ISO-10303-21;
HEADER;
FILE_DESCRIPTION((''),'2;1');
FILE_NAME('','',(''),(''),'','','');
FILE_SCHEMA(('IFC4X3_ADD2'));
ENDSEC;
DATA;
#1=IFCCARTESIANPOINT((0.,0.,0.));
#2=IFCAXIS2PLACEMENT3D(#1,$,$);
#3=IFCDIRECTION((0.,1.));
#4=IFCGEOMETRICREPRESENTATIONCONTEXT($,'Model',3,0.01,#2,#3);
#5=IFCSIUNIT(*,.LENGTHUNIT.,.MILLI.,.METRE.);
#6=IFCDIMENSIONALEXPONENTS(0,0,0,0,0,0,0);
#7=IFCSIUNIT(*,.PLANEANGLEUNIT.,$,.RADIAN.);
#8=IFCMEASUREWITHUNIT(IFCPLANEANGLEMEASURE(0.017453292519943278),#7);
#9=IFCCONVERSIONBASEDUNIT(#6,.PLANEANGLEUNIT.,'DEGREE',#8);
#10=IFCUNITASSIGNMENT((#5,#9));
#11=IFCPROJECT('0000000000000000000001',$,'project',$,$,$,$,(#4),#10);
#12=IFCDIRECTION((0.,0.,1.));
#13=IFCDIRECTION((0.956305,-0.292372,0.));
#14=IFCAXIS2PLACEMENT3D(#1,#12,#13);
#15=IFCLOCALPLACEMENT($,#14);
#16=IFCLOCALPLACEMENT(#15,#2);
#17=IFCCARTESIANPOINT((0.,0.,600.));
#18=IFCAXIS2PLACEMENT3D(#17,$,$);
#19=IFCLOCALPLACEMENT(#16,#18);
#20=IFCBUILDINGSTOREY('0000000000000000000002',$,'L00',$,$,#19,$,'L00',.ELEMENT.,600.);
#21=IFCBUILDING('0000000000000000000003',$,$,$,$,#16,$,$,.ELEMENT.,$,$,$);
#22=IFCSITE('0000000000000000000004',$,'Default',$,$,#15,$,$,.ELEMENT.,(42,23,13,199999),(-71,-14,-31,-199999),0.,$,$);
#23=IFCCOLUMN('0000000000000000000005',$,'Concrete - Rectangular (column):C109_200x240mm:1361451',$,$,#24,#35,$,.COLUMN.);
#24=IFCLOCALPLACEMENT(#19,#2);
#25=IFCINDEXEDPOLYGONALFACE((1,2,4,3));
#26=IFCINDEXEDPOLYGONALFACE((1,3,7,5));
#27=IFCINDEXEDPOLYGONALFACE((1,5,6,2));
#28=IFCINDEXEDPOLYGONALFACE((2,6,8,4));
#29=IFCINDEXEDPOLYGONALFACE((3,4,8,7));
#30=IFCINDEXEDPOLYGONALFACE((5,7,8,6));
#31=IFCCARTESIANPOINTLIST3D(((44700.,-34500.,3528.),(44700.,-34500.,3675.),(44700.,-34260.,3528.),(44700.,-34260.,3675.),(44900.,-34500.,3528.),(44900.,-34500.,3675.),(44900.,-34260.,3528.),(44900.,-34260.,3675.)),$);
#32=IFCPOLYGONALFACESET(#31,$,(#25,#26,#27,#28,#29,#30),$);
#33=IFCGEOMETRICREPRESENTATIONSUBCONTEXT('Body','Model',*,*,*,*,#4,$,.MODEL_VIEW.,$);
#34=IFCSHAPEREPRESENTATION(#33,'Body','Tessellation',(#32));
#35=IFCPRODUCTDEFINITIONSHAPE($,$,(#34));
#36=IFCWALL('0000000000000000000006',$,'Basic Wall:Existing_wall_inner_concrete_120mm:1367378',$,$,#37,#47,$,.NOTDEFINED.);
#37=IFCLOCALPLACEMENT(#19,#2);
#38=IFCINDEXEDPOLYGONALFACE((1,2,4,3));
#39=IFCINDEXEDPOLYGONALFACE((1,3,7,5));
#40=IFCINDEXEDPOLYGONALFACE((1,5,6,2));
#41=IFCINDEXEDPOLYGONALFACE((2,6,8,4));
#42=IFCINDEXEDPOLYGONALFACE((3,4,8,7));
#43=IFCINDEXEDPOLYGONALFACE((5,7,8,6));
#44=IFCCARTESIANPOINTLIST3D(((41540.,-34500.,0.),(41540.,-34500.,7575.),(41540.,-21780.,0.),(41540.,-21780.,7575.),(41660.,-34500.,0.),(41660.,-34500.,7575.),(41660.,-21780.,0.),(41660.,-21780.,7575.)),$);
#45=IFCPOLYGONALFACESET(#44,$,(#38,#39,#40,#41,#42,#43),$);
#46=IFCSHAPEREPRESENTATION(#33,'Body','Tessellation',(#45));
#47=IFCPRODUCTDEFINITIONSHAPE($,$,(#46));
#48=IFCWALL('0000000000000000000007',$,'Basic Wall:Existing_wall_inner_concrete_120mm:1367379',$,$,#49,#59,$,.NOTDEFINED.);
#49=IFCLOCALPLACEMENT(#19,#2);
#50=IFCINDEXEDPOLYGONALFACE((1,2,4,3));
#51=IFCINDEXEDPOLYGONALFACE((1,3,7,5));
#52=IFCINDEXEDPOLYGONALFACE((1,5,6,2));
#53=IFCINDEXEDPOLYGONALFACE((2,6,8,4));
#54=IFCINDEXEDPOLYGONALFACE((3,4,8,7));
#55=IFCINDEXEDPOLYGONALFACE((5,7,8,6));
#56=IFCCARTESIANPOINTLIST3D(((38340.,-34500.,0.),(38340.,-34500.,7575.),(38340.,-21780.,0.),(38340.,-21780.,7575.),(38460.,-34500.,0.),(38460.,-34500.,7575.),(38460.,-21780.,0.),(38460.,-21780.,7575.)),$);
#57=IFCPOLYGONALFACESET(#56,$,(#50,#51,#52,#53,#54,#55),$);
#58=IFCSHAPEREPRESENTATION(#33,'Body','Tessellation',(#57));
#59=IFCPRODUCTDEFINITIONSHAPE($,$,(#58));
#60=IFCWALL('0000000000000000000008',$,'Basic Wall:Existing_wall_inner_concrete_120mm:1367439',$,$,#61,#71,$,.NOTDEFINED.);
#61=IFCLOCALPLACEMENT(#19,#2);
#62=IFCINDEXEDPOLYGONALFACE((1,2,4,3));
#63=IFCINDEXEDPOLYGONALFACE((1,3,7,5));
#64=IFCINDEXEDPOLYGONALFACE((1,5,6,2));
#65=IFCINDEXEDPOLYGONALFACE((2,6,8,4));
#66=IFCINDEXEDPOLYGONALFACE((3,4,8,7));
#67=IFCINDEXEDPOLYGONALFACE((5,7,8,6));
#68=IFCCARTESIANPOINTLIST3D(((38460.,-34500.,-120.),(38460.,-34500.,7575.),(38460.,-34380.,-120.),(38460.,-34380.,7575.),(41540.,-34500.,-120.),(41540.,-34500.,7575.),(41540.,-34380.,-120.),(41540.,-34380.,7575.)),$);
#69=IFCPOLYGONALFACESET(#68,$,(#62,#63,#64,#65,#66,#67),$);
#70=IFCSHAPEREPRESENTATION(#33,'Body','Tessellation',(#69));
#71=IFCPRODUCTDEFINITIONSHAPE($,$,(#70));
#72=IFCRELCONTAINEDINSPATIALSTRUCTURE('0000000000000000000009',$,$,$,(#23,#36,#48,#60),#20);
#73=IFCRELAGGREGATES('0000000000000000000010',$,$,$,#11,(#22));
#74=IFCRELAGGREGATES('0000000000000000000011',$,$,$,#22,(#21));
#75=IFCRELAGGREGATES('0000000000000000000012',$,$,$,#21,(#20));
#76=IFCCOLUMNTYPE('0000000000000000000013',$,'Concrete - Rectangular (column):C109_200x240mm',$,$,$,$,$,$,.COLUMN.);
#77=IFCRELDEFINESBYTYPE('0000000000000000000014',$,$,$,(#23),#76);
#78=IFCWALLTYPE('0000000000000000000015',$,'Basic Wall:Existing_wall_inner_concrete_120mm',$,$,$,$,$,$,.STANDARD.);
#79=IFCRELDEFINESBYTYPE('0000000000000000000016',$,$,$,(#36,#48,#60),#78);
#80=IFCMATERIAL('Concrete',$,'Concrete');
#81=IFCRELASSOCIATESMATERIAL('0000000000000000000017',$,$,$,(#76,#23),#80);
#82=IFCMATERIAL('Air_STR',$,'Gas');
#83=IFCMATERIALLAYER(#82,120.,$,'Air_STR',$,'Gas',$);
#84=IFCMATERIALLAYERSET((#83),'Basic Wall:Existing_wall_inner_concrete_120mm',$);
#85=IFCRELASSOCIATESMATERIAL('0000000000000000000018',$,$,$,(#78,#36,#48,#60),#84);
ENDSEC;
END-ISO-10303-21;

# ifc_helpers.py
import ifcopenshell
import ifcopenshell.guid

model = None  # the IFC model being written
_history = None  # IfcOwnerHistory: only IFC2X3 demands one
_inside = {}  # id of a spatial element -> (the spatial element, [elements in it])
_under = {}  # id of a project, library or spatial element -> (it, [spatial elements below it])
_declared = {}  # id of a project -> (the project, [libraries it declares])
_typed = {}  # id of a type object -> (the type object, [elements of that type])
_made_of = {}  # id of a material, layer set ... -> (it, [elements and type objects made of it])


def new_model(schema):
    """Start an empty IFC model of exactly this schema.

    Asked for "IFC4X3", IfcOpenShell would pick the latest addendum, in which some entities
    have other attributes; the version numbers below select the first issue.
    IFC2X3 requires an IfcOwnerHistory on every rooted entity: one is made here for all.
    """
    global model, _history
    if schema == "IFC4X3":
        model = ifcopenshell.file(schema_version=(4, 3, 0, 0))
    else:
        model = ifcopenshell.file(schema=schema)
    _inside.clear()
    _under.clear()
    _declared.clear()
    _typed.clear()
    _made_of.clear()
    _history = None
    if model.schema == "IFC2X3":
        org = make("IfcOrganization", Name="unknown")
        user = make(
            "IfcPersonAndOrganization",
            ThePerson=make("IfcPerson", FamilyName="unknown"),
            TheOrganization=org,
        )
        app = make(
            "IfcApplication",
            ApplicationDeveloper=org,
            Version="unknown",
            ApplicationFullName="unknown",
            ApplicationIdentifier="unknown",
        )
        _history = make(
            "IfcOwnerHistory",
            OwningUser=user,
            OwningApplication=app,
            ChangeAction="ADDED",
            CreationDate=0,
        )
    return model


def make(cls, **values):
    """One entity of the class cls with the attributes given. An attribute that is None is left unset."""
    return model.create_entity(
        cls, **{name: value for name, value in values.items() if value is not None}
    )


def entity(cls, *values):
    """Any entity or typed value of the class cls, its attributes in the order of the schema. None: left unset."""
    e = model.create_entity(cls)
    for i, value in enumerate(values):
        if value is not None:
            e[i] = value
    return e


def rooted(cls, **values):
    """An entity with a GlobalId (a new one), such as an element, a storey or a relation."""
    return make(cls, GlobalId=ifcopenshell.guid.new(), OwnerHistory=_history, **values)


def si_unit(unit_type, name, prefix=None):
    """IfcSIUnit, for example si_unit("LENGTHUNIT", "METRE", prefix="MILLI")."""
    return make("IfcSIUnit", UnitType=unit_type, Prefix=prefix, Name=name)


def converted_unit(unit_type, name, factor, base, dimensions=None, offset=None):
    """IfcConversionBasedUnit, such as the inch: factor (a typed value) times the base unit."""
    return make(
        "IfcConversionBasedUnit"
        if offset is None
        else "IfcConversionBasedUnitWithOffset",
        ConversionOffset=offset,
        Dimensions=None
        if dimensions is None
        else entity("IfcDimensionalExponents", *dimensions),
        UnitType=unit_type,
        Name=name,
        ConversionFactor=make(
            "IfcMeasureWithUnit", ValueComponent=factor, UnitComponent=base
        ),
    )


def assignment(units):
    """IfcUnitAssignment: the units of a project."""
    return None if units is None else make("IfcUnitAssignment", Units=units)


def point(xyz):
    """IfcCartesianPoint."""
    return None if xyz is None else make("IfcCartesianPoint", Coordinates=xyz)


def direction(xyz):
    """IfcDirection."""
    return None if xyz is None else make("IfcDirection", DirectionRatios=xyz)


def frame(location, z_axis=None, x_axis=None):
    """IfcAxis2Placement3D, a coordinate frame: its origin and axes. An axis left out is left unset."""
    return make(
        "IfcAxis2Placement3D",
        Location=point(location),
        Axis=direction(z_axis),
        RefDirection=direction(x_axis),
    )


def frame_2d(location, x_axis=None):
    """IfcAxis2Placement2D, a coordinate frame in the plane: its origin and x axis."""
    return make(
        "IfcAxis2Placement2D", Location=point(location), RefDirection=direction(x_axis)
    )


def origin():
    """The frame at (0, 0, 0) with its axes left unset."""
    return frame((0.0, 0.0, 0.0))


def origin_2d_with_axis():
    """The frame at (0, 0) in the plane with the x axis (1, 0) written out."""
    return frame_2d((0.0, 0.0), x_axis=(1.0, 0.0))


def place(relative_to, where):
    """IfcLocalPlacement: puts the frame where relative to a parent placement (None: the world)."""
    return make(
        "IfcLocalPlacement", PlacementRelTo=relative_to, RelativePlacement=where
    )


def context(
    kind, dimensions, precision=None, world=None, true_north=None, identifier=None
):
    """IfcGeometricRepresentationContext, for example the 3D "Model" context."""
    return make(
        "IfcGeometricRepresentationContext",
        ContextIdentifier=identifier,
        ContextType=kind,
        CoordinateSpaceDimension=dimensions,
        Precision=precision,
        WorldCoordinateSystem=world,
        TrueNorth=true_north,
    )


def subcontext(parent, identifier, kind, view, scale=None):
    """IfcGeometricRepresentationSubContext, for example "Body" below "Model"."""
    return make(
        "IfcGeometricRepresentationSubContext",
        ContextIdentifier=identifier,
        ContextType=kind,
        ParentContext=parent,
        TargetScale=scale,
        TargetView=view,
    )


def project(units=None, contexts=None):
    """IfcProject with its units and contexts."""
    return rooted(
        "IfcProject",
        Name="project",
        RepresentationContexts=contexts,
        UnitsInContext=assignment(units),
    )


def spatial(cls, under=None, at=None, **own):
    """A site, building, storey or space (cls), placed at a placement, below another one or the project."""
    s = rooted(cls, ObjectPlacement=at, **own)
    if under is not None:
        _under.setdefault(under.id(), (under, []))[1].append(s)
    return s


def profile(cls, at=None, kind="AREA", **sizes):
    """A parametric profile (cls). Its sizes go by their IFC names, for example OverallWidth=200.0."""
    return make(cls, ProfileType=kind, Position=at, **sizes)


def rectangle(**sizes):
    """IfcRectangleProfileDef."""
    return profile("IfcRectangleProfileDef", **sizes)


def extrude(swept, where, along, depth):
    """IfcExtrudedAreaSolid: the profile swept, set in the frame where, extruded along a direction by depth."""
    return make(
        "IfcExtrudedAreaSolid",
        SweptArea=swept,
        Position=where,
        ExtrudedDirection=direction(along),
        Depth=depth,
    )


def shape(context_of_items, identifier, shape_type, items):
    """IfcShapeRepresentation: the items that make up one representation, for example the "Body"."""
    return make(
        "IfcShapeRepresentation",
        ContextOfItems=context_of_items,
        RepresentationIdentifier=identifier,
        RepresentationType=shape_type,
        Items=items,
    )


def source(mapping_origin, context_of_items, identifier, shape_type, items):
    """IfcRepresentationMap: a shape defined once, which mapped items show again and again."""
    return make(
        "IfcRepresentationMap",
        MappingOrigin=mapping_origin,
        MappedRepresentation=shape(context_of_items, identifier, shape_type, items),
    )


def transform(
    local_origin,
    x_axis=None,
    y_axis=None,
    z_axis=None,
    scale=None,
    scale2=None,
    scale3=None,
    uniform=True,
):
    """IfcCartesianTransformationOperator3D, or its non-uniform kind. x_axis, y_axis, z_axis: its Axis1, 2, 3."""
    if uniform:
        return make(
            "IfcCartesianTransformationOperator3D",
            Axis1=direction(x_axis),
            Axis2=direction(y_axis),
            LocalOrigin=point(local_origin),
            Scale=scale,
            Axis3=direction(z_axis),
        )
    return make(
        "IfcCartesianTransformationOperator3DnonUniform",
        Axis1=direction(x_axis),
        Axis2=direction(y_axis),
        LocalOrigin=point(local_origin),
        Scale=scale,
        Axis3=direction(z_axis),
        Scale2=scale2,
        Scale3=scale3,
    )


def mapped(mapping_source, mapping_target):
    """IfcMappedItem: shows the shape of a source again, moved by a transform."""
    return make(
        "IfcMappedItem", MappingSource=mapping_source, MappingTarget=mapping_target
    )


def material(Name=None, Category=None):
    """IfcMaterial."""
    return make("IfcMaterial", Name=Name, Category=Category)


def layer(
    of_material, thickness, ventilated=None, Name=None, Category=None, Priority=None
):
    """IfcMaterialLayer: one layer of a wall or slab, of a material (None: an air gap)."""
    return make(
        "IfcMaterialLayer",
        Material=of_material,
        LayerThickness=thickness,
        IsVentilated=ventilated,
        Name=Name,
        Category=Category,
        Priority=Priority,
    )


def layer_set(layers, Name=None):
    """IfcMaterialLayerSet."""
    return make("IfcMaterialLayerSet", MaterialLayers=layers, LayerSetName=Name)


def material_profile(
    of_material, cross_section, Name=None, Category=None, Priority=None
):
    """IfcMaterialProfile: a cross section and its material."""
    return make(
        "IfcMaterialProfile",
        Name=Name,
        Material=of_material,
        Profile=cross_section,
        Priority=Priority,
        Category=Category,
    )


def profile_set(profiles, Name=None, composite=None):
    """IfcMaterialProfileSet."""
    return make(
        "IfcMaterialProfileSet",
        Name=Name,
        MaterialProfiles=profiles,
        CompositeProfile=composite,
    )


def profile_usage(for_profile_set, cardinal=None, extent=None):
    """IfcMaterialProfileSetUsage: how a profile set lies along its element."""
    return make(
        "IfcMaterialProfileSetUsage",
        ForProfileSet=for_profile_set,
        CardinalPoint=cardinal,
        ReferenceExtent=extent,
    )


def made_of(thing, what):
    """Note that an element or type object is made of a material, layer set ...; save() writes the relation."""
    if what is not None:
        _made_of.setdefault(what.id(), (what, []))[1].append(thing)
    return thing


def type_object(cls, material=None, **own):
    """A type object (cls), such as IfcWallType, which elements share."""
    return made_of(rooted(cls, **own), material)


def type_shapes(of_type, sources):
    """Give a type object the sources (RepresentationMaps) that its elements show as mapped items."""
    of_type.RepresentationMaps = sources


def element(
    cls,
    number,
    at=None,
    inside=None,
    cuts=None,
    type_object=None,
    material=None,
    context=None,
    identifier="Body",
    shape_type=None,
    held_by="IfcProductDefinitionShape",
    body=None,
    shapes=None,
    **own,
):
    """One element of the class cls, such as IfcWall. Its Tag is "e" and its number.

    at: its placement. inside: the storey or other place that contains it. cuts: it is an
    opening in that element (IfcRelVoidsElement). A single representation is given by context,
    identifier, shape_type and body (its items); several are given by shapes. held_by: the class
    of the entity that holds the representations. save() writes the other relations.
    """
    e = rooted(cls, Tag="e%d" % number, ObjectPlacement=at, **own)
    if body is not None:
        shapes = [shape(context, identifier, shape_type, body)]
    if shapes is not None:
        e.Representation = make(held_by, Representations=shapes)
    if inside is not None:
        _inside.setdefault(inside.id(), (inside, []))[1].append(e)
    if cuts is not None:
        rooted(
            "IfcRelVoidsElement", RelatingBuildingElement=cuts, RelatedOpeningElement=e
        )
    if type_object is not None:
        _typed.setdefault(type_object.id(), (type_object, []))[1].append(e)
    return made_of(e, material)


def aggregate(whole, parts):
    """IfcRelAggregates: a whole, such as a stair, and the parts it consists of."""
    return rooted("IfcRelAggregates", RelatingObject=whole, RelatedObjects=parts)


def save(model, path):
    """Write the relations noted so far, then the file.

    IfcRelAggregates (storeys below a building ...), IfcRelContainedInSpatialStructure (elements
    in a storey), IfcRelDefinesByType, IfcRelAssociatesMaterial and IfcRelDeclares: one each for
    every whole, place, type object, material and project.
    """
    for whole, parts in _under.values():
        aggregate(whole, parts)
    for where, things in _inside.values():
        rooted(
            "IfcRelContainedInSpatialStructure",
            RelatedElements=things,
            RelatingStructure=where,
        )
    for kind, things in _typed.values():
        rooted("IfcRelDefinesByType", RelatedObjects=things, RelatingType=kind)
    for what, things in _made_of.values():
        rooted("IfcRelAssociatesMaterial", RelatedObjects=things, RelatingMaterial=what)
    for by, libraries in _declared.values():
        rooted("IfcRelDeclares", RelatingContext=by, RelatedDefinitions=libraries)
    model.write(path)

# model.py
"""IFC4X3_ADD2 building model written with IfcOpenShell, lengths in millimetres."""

from ifc_helpers import new_model, entity, si_unit, converted_unit, direction, frame, frame_2d, origin, origin_2d_with_axis, place, context, subcontext, project, spatial, rectangle, extrude, source, transform, mapped, material, layer, layer_set, material_profile, profile_set, profile_usage, type_object, type_shapes, element, save


model = new_model("IFC4X3_ADD2")

# Units and contexts
model_context = context("Model", 3, precision=0.01, world=origin(), true_north=direction((0.0, 1.0)))
body_context = subcontext(model_context, "Body", "Model", "MODEL_VIEW")
ifc_project = project(units=[si_unit("LENGTHUNIT", "METRE", prefix="MILLI"), converted_unit("PLANEANGLEUNIT", "DEGREE", entity("IfcPlaneAngleMeasure", 0.017453292519943278), si_unit("PLANEANGLEUNIT", "RADIAN"), dimensions=[0, 0, 0, 0, 0, 0, 0])], contexts=[model_context])

# Site, building, storey
site_placement = place(None, frame((0.0, 0.0, 0.0), z_axis=(0.0, 0.0, 1.0), x_axis=(0.956305, -0.292372, 0.0)))
site = spatial("IfcSite", under=ifc_project, at=site_placement, Name="Default", CompositionType="ELEMENT", RefLatitude=(42, 23, 13, 199999), RefLongitude=(-71, -14, -31, -199999), RefElevation=0.0)
building_placement = place(site_placement, origin())
building = spatial("IfcBuilding", under=site, at=building_placement, CompositionType="ELEMENT")
storey_placement = place(building_placement, frame((0.0, 0.0, 600.0)))
storey = spatial("IfcBuildingStorey", under=building, at=storey_placement, Name="L00", LongName="L00", CompositionType="ELEMENT", Elevation=600.0)

# Column
ifc_material_1 = material(Name="Concrete", Category="Concrete")
ifc_material_profile_1 = material_profile(ifc_material_1, rectangle(XDim=200.0, YDim=240.0, at=frame_2d((0.0, 0.0), x_axis=(1.0, 0.0))), Name="C109_200x240mm")
ifc_profile_set_1 = profile_set([ifc_material_profile_1], Name="C109_200x240mm")
ifc_profile_usage_1 = profile_usage(ifc_profile_set_1)
column_type = type_object("IfcColumnType", Name="Concrete - Rectangular (column):C109_200x240mm", PredefinedType="COLUMN", material=ifc_profile_set_1)
shared_shape_1 = source(origin(), body_context, "Body", "SweptSolid", [
    extrude(rectangle(XDim=200.0, YDim=240.0, at=origin_2d_with_axis()), frame((0.0, 0.0, 4128.0), z_axis=(0.0, 0.0, 1.0), x_axis=(-1.0, 0.0, 0.0)), (0.0, 0.0, 1.0), 147.0),
])
type_shapes(column_type, [shared_shape_1])
column_placement = place(storey_placement, frame((44800.0, -34380.0, -600.0)))
element("IfcColumn", 1, at=column_placement, inside=storey, type_object=column_type, material=ifc_profile_usage_1, Name="Concrete - Rectangular (column):C109_200x240mm:1361451", PredefinedType="COLUMN", context=body_context, shape_type="MappedRepresentation", body=[
    mapped(shared_shape_1, transform((0.0, 0.0, 0.0), scale=1.0)),
])

# Walls
ifc_material_2 = material(Name="Air_STR", Category="Gas")
ifc_layer = layer(ifc_material_2, 120.0, Name="Air_STR", Category="Gas")
ifc_layer_set = layer_set([ifc_layer], Name="Basic Wall:Existing_wall_inner_concrete_120mm")
wall_type = type_object("IfcWallType", Name="Basic Wall:Existing_wall_inner_concrete_120mm", PredefinedType="STANDARD", material=ifc_layer_set)
wall_1_placement = place(storey_placement, frame((41600.0, -34500.0, 0.0), z_axis=(0.0, 0.0, 1.0), x_axis=(0.0, 1.0, 0.0)))
element("IfcWall", 2, at=wall_1_placement, inside=storey, type_object=wall_type, material=ifc_layer_set, Name="Basic Wall:Existing_wall_inner_concrete_120mm:1367378", PredefinedType="NOTDEFINED", context=body_context, shape_type="SweptSolid", body=[
    extrude(rectangle(XDim=12720.0, YDim=120.0, at=frame_2d((6360.0, 0.0), x_axis=(-1.0, 0.0))), origin(), (0.0, 0.0, 1.0), 7575.0),
])
wall_2_placement = place(storey_placement, frame((38400.0, -34500.0, 0.0), z_axis=(0.0, 0.0, 1.0), x_axis=(0.0, 1.0, 0.0)))
element("IfcWall", 3, at=wall_2_placement, inside=storey, type_object=wall_type, material=ifc_layer_set, Name="Basic Wall:Existing_wall_inner_concrete_120mm:1367379", PredefinedType="NOTDEFINED", context=body_context, shape_type="SweptSolid", body=[
    extrude(rectangle(XDim=12720.0, YDim=120.0, at=frame_2d((6360.0, 0.0), x_axis=(-1.0, 0.0))), origin(), (0.0, 0.0, 1.0), 7575.0),
])
wall_3_placement = place(storey_placement, frame((38460.0, -34440.0, -120.0)))
element("IfcWall", 4, at=wall_3_placement, inside=storey, type_object=wall_type, material=ifc_layer_set, Name="Basic Wall:Existing_wall_inner_concrete_120mm:1367439", PredefinedType="NOTDEFINED", context=body_context, shape_type="SweptSolid", body=[
    extrude(rectangle(XDim=3080.0, YDim=120.0, at=frame_2d((1540.0, 0.0), x_axis=(-1.0, 0.0))), origin(), (0.0, 0.0, 1.0), 7695.0),
])

save(model, "model.ifc")
